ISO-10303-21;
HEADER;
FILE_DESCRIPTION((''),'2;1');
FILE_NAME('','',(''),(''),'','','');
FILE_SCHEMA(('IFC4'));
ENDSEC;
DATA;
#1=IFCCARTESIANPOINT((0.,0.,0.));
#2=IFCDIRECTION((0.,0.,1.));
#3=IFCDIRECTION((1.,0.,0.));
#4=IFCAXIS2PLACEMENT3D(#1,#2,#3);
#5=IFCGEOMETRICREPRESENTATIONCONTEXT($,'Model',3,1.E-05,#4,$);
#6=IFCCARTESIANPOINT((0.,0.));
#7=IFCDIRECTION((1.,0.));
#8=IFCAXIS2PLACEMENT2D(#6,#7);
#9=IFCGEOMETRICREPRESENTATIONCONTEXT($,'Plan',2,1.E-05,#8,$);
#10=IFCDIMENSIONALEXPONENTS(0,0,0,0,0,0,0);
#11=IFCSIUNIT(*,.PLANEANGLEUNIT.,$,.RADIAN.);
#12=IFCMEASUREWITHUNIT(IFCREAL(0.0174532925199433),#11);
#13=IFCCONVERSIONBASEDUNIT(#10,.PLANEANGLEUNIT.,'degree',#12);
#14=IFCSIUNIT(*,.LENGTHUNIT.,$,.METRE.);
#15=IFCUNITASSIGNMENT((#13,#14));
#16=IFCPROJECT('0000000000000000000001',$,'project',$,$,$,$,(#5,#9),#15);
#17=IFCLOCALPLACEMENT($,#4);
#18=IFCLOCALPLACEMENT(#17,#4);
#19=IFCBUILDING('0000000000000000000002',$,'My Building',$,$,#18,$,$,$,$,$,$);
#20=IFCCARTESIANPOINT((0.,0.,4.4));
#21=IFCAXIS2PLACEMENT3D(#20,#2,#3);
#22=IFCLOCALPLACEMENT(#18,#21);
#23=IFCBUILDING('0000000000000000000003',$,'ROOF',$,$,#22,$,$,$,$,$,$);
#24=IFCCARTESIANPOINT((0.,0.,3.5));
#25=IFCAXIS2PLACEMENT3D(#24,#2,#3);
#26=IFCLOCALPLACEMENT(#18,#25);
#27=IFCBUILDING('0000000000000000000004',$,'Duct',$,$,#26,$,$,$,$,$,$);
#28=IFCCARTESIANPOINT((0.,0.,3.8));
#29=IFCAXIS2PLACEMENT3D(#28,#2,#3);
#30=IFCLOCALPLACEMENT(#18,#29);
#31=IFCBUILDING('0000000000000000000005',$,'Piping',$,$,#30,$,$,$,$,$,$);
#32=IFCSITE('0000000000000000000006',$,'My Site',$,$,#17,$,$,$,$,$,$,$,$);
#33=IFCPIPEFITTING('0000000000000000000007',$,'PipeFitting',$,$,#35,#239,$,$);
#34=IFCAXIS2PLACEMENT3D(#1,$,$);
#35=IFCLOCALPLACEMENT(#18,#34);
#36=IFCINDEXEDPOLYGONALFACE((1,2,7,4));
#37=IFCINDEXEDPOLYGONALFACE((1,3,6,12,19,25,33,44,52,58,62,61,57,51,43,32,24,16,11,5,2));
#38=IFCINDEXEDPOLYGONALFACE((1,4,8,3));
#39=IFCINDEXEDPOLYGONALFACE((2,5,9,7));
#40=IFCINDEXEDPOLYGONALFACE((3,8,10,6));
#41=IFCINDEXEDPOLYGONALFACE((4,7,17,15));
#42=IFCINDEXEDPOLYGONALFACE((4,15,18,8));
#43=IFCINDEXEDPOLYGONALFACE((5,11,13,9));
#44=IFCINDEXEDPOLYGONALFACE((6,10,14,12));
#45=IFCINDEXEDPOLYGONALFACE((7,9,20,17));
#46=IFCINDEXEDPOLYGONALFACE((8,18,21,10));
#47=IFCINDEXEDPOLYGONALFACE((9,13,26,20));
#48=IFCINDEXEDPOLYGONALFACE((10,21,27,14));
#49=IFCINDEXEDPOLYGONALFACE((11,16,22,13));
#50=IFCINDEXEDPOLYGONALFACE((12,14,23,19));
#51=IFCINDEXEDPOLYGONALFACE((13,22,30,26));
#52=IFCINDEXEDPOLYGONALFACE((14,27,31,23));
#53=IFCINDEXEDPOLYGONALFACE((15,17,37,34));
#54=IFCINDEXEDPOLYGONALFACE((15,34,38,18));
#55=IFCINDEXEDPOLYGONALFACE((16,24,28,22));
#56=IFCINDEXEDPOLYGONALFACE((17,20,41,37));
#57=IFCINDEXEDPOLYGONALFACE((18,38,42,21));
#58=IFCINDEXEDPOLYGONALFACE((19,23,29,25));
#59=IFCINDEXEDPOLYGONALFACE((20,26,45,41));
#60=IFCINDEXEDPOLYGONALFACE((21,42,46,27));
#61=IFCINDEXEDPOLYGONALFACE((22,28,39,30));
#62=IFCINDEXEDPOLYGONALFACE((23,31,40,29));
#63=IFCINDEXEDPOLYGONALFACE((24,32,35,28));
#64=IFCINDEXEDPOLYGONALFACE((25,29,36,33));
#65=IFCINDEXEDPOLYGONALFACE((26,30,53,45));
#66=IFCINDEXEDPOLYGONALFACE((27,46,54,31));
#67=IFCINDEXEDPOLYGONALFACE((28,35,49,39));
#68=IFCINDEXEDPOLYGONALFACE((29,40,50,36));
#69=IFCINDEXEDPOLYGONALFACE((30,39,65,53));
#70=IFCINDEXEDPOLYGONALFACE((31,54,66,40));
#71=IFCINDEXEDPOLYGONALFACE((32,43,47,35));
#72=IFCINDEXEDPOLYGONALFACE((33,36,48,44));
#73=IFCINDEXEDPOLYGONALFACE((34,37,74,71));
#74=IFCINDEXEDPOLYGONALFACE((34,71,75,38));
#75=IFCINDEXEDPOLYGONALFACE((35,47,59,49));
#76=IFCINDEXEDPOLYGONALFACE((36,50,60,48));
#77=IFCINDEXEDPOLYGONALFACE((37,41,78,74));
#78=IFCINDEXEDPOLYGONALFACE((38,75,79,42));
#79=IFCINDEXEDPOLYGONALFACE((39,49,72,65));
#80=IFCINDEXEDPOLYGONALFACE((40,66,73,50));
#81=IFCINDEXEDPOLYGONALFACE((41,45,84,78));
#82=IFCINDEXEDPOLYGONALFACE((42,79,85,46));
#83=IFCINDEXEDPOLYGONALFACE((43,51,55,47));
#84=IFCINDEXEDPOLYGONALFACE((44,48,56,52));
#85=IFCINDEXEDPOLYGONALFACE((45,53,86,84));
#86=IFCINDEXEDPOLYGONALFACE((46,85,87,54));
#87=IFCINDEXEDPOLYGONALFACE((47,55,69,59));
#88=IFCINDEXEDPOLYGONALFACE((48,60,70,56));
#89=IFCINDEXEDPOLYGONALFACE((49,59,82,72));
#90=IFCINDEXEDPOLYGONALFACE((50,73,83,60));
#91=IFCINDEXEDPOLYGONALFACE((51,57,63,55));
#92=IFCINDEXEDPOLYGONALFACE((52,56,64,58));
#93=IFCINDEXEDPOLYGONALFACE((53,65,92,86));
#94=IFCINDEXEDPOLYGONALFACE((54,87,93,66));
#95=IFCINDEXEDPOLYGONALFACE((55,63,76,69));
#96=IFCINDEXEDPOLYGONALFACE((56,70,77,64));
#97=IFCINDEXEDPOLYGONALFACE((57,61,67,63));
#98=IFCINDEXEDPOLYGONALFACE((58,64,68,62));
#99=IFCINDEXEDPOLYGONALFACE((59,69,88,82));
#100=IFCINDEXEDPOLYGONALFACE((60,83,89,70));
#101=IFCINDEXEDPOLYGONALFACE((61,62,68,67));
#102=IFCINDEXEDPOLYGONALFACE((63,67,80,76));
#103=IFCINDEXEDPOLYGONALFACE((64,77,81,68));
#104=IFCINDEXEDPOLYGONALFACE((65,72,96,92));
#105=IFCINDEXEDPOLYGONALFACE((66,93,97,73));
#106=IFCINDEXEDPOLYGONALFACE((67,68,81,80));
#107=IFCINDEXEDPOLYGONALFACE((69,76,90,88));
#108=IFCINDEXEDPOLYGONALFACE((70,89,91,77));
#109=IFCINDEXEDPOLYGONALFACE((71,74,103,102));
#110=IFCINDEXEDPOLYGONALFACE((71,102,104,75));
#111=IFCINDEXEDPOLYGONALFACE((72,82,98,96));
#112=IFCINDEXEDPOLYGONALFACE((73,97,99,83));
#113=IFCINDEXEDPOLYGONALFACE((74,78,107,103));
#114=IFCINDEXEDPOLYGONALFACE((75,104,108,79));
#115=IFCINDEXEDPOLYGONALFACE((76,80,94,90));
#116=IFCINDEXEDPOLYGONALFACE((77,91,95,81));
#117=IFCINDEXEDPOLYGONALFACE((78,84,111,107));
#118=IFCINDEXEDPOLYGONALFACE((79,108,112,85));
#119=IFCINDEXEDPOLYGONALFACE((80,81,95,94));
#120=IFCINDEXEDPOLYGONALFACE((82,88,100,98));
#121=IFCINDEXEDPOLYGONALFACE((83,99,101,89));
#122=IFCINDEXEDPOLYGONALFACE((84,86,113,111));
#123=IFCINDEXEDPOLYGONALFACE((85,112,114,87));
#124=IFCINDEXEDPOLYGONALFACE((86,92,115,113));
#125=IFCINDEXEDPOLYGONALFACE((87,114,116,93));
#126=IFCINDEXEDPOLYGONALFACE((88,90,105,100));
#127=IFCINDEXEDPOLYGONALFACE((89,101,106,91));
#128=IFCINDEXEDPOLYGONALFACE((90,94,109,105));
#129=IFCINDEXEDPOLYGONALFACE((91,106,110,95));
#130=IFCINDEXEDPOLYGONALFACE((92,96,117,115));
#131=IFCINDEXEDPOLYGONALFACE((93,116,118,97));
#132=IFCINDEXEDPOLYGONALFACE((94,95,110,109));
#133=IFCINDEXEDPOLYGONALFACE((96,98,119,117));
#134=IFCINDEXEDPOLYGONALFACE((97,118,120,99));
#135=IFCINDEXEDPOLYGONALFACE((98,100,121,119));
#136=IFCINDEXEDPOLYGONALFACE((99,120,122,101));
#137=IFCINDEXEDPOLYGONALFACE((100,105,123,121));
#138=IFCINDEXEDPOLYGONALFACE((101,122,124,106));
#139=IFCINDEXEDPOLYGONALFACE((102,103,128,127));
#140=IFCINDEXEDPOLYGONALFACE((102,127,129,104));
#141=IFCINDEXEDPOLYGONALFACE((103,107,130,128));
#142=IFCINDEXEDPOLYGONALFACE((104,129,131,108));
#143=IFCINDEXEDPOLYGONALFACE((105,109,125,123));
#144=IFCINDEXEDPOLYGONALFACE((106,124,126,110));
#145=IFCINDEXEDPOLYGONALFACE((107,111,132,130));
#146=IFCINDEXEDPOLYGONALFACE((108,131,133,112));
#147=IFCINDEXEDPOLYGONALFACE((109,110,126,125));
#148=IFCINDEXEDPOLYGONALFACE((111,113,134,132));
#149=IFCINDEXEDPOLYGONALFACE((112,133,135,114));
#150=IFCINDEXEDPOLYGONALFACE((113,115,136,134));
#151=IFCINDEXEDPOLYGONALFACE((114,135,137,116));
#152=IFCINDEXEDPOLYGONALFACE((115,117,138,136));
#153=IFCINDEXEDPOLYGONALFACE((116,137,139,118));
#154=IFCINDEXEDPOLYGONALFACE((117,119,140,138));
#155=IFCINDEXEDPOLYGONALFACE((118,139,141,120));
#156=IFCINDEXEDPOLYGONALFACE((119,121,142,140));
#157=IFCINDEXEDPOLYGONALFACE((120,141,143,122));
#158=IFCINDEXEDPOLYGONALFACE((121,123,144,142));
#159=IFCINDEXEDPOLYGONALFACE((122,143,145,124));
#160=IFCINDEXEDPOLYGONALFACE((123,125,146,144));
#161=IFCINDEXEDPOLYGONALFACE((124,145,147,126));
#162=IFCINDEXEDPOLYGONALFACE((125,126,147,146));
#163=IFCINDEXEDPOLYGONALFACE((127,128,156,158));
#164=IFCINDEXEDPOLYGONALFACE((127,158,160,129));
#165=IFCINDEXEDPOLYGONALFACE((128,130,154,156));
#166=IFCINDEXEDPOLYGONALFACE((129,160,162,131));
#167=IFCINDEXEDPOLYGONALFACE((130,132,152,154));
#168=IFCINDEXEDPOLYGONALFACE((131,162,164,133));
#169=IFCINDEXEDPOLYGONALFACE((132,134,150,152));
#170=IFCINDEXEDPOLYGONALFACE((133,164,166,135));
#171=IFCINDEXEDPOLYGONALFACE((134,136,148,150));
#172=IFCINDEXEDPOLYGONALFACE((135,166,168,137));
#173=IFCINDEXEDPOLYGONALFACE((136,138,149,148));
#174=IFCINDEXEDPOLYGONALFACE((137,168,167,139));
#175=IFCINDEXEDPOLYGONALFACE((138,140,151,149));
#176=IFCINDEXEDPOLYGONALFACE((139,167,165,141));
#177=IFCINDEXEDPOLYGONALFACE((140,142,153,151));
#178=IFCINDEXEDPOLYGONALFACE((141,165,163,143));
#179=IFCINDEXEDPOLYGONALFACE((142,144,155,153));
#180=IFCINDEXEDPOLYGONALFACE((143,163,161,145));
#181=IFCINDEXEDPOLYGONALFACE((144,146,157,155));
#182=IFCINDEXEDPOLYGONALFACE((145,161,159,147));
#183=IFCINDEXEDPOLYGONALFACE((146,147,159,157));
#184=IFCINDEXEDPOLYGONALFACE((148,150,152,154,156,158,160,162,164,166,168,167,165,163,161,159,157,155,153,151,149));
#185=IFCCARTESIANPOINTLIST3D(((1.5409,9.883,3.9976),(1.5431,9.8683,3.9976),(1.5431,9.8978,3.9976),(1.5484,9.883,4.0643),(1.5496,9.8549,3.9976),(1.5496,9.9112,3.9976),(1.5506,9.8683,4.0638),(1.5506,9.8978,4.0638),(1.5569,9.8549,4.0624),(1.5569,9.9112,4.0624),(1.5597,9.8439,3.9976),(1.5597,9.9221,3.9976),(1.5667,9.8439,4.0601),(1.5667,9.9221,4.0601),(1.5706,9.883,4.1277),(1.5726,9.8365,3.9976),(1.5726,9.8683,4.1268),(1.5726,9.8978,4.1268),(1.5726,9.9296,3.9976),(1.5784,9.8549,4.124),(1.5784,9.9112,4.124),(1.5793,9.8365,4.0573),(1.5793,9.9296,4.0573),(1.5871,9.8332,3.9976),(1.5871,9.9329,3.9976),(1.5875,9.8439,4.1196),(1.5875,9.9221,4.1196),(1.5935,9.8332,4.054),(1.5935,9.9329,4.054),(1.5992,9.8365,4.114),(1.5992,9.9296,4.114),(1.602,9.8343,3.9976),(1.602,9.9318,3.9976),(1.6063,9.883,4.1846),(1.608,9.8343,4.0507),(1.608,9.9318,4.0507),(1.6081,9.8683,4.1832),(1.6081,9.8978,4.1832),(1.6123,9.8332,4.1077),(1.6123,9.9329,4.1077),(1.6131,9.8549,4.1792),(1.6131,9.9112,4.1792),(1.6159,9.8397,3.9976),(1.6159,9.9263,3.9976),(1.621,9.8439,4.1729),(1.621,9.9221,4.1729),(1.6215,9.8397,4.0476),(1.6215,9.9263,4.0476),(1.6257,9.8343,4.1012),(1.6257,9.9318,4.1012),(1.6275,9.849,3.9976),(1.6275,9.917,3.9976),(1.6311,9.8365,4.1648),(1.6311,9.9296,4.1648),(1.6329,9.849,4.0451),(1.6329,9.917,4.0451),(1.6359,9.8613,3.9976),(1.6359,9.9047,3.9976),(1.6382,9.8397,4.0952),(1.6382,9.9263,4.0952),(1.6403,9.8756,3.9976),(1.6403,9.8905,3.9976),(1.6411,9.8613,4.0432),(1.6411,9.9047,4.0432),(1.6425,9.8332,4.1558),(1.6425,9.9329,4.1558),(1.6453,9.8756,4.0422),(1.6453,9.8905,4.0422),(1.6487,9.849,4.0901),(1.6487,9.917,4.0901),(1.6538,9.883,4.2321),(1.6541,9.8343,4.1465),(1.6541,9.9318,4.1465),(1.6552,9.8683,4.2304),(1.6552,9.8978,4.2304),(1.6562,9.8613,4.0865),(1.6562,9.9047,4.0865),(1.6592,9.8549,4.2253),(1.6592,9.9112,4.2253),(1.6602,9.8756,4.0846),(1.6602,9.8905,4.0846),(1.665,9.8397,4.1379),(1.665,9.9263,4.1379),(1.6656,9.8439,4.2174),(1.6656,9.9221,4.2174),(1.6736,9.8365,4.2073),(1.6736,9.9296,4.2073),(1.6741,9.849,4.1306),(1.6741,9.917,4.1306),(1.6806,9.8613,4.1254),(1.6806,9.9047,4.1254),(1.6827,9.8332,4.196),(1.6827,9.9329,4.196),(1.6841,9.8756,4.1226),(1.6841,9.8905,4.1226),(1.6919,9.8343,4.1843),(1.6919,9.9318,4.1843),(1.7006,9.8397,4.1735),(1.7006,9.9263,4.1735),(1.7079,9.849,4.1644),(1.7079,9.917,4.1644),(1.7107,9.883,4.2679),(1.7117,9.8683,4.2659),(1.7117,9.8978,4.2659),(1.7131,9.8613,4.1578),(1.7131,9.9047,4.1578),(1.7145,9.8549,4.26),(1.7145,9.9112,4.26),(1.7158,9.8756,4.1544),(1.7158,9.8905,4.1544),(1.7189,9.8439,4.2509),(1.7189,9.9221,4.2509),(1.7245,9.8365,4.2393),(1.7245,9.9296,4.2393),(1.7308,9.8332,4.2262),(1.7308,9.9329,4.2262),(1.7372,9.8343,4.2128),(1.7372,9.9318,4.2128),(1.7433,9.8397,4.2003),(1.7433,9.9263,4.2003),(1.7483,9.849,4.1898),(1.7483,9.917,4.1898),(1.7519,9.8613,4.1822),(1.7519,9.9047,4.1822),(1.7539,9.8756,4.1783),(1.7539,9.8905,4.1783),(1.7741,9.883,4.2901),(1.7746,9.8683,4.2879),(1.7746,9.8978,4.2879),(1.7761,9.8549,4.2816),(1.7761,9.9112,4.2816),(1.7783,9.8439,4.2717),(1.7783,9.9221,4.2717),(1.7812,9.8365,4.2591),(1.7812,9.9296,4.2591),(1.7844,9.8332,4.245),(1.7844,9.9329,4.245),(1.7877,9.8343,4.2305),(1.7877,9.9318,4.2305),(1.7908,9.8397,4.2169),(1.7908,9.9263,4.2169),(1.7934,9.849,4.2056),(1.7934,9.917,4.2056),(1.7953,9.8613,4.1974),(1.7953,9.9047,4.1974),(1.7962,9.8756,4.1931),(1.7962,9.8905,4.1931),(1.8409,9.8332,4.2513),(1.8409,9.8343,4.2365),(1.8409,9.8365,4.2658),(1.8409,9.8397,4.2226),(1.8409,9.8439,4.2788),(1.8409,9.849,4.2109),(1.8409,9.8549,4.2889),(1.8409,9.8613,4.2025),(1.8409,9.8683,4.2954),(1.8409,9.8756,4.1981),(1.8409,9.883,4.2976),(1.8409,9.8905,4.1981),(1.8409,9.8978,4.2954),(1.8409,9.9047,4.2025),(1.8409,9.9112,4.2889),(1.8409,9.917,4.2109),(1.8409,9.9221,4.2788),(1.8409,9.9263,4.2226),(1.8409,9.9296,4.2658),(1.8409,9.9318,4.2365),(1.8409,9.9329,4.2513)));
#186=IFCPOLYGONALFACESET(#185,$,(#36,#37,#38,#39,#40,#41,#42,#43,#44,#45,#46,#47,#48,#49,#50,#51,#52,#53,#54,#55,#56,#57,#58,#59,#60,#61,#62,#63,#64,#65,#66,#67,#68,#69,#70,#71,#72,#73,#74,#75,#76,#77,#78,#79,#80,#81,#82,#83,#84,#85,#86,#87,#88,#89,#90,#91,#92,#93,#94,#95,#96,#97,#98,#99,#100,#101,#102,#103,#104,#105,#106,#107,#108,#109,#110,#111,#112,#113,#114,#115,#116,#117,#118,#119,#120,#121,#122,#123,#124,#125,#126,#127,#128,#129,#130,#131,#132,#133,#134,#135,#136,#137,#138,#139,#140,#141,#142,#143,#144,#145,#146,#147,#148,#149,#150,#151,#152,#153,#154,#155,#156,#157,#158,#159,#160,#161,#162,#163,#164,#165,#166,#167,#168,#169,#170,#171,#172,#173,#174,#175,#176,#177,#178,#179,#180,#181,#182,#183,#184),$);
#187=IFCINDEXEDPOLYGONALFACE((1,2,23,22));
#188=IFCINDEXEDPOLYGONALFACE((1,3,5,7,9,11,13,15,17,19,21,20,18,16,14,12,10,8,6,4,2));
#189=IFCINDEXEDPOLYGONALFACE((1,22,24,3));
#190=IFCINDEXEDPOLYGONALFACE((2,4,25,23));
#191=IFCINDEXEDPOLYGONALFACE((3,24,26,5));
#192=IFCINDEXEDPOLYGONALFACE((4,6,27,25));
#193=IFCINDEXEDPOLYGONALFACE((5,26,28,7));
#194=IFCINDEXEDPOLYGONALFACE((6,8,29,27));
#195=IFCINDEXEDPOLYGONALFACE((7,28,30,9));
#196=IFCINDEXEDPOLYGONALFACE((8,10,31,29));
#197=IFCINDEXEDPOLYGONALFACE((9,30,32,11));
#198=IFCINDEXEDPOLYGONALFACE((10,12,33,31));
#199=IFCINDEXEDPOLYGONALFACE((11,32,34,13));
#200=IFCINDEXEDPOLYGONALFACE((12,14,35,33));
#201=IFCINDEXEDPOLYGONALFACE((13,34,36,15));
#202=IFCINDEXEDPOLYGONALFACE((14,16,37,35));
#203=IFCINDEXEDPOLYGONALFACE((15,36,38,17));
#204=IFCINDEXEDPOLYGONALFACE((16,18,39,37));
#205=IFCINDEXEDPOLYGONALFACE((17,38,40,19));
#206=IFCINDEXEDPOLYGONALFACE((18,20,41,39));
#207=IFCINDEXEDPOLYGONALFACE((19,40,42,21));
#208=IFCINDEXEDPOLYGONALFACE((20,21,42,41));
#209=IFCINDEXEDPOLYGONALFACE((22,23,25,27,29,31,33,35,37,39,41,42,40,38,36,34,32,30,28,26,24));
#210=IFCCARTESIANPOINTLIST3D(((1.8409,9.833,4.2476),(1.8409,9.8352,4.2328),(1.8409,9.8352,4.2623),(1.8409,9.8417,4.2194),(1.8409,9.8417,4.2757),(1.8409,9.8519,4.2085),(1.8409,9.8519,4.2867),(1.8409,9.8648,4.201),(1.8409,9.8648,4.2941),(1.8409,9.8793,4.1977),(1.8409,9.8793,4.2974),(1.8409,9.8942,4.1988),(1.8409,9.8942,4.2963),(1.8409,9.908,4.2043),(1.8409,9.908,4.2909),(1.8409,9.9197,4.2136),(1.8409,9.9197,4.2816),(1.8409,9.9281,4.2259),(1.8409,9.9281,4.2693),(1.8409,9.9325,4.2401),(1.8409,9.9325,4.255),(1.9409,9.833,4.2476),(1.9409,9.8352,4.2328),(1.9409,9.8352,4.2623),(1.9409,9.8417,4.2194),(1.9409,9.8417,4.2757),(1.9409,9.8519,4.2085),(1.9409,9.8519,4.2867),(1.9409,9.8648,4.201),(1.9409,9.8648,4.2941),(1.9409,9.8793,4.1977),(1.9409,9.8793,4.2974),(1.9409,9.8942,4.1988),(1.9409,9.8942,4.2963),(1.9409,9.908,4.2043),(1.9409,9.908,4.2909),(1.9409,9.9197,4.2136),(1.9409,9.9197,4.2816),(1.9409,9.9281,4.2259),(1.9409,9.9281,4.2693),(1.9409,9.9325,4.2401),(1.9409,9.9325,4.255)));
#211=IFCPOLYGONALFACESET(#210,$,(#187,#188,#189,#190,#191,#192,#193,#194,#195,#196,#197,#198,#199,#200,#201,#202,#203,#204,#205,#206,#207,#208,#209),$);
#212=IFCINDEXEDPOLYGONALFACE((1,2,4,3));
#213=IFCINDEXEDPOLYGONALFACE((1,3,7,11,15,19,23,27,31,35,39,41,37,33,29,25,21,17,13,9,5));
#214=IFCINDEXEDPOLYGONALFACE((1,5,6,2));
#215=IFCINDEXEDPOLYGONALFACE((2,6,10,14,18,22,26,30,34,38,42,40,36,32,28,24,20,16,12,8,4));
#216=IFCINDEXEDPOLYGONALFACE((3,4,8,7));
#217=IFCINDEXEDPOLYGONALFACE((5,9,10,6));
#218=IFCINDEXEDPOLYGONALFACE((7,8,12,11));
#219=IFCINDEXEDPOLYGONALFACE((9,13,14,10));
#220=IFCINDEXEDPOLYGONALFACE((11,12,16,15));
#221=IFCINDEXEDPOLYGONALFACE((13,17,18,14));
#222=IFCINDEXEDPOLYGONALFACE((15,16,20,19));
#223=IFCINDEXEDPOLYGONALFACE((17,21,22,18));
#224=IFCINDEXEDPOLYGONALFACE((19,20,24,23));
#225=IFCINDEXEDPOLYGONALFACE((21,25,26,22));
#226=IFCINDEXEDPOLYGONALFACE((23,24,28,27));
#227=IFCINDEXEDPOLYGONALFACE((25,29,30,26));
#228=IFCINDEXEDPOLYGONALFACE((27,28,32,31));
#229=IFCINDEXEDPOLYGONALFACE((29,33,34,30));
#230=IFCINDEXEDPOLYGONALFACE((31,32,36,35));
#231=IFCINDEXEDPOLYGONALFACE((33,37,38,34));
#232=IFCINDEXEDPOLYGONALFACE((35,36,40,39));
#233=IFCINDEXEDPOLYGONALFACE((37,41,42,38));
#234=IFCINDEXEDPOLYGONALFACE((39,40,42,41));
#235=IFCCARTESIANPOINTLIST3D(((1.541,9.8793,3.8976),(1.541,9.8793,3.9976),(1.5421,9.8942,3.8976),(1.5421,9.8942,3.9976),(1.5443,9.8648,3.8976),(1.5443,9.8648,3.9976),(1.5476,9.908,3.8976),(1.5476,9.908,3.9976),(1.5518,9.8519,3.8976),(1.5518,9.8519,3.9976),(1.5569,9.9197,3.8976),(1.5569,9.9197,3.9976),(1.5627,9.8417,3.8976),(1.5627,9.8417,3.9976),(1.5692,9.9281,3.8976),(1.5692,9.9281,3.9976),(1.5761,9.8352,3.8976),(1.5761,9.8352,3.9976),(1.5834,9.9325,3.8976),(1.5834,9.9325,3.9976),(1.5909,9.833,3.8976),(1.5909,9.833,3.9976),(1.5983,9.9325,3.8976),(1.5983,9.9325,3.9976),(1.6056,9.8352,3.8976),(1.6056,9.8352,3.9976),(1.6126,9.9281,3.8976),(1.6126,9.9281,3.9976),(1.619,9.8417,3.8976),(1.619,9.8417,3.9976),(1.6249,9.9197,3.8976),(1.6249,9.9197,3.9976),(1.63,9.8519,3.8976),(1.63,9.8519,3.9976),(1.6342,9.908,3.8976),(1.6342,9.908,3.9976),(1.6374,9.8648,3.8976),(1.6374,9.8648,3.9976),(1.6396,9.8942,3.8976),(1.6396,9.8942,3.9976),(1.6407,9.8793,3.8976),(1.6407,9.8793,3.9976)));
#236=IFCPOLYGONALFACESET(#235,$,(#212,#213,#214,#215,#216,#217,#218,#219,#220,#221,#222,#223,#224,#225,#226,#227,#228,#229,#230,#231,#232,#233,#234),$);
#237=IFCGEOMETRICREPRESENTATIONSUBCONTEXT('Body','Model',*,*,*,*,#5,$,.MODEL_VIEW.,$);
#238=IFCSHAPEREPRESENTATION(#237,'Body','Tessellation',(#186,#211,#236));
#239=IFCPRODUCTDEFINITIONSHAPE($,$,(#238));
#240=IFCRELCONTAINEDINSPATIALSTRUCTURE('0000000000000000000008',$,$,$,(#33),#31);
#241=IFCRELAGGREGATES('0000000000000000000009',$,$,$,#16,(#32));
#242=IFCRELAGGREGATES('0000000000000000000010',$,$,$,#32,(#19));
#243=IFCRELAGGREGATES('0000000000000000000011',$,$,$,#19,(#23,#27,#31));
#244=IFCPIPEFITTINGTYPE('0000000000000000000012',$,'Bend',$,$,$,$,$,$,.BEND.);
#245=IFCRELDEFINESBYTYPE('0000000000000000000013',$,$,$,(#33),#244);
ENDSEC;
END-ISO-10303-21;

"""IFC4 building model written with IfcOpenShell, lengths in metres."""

from ifc_helpers import new_model, entity, si_unit, converted_unit, frame, origin_with_axes, origin_2d_with_axis, place, context, subcontext, project, spatial, circle, extrude, source, transform, mapped, type_object, type_shapes, element, save


model = new_model("IFC4")

# Units and contexts
model_context = context("Model", 3, precision=1e-05, world=origin_with_axes())
plan_context = context("Plan", 2, precision=1e-05, world=origin_2d_with_axis())
body_context_1 = subcontext(model_context, "Body", "Model", "MODEL_VIEW")
ifc_project = project(units=[converted_unit("PLANEANGLEUNIT", "degree", entity("IfcReal", 0.0174532925199433), si_unit("PLANEANGLEUNIT", "RADIAN"), dimensions=[0, 0, 0, 0, 0, 0, 0]), si_unit("LENGTHUNIT", "METRE")], contexts=[model_context, plan_context])

# Site, building
site_placement = place(None, origin_with_axes())
site = spatial("IfcSite", under=ifc_project, at=site_placement, Name="My Site")
building_1_placement = place(site_placement, origin_with_axes())
building_1 = spatial("IfcBuilding", under=site, at=building_1_placement, Name="My Building")

# Shared definitions
building_2_placement = place(building_1_placement, frame((0.0, 0.0, 4.4), z_axis=(0.0, 0.0, 1.0), x_axis=(1.0, 0.0, 0.0)))
building_2 = spatial("IfcBuilding", under=building_1, at=building_2_placement, Name="ROOF")

# Shared definitions
building_3_placement = place(building_1_placement, frame((0.0, 0.0, 3.5), z_axis=(0.0, 0.0, 1.0), x_axis=(1.0, 0.0, 0.0)))
building_3 = spatial("IfcBuilding", under=building_1, at=building_3_placement, Name="Duct")

# Shared definitions
building_4_placement = place(building_1_placement, frame((0.0, 0.0, 3.8), z_axis=(0.0, 0.0, 1.0), x_axis=(1.0, 0.0, 0.0)))
building_4 = spatial("IfcBuilding", under=building_1, at=building_4_placement, Name="Piping")

# Pipe fitting
pipe_fitting_type_1 = type_object("IfcPipeFittingType", Name="Bend", PredefinedType="BEND")
shared_shape_1 = source(origin_with_axes(), body_context_1, "Body", "SolidModel", [
    entity("IfcSweptDiskSolid", entity("IfcIndexedPolyCurve", entity("IfcCartesianPointList3D", [[0.0, 0.0, 0.1], [0.0, -0.0732, 0.2768], [0.0, -0.25, 0.35]]), [entity("IfcArcIndex", [1, 2, 3])]), 0.05),
    extrude(circle(Radius=0.05), origin_with_axes(), (0.0, 0.0, 1.0), 0.1),
    extrude(circle(Radius=0.05), frame((0.0, -0.25, 0.35), z_axis=(0.0, -1.0, -0.000001), x_axis=(1.0, 0.0, 0.0)), (0.0, 0.0, 1.0), 0.1),
])
type_shapes(pipe_fitting_type_1, [shared_shape_1])
for number, where, z_axis, x_axis, name in (
    (1, (1.9409, 9.883, 0.4476), (-1.0, 0.000001, -0.000001), (-0.000001, -1.0, 0.0), "PipeFitting"),
):
    element("IfcPipeFitting", number, at=place(building_4_placement, frame(where, z_axis=z_axis, x_axis=x_axis)), inside=building_4, type_object=pipe_fitting_type_1, Name=name, context=body_context_1, shape_type="MappedRepresentation", body=[
        mapped(shared_shape_1, transform((0.0, 0.0, 0.0), x_axis=(1.0, 0.0, 0.0), y_axis=(0.0, 1.0, 0.0), z_axis=(0.0, 0.0, 1.0), scale=1.0)),
    ])

save(model, "model.ifc")
